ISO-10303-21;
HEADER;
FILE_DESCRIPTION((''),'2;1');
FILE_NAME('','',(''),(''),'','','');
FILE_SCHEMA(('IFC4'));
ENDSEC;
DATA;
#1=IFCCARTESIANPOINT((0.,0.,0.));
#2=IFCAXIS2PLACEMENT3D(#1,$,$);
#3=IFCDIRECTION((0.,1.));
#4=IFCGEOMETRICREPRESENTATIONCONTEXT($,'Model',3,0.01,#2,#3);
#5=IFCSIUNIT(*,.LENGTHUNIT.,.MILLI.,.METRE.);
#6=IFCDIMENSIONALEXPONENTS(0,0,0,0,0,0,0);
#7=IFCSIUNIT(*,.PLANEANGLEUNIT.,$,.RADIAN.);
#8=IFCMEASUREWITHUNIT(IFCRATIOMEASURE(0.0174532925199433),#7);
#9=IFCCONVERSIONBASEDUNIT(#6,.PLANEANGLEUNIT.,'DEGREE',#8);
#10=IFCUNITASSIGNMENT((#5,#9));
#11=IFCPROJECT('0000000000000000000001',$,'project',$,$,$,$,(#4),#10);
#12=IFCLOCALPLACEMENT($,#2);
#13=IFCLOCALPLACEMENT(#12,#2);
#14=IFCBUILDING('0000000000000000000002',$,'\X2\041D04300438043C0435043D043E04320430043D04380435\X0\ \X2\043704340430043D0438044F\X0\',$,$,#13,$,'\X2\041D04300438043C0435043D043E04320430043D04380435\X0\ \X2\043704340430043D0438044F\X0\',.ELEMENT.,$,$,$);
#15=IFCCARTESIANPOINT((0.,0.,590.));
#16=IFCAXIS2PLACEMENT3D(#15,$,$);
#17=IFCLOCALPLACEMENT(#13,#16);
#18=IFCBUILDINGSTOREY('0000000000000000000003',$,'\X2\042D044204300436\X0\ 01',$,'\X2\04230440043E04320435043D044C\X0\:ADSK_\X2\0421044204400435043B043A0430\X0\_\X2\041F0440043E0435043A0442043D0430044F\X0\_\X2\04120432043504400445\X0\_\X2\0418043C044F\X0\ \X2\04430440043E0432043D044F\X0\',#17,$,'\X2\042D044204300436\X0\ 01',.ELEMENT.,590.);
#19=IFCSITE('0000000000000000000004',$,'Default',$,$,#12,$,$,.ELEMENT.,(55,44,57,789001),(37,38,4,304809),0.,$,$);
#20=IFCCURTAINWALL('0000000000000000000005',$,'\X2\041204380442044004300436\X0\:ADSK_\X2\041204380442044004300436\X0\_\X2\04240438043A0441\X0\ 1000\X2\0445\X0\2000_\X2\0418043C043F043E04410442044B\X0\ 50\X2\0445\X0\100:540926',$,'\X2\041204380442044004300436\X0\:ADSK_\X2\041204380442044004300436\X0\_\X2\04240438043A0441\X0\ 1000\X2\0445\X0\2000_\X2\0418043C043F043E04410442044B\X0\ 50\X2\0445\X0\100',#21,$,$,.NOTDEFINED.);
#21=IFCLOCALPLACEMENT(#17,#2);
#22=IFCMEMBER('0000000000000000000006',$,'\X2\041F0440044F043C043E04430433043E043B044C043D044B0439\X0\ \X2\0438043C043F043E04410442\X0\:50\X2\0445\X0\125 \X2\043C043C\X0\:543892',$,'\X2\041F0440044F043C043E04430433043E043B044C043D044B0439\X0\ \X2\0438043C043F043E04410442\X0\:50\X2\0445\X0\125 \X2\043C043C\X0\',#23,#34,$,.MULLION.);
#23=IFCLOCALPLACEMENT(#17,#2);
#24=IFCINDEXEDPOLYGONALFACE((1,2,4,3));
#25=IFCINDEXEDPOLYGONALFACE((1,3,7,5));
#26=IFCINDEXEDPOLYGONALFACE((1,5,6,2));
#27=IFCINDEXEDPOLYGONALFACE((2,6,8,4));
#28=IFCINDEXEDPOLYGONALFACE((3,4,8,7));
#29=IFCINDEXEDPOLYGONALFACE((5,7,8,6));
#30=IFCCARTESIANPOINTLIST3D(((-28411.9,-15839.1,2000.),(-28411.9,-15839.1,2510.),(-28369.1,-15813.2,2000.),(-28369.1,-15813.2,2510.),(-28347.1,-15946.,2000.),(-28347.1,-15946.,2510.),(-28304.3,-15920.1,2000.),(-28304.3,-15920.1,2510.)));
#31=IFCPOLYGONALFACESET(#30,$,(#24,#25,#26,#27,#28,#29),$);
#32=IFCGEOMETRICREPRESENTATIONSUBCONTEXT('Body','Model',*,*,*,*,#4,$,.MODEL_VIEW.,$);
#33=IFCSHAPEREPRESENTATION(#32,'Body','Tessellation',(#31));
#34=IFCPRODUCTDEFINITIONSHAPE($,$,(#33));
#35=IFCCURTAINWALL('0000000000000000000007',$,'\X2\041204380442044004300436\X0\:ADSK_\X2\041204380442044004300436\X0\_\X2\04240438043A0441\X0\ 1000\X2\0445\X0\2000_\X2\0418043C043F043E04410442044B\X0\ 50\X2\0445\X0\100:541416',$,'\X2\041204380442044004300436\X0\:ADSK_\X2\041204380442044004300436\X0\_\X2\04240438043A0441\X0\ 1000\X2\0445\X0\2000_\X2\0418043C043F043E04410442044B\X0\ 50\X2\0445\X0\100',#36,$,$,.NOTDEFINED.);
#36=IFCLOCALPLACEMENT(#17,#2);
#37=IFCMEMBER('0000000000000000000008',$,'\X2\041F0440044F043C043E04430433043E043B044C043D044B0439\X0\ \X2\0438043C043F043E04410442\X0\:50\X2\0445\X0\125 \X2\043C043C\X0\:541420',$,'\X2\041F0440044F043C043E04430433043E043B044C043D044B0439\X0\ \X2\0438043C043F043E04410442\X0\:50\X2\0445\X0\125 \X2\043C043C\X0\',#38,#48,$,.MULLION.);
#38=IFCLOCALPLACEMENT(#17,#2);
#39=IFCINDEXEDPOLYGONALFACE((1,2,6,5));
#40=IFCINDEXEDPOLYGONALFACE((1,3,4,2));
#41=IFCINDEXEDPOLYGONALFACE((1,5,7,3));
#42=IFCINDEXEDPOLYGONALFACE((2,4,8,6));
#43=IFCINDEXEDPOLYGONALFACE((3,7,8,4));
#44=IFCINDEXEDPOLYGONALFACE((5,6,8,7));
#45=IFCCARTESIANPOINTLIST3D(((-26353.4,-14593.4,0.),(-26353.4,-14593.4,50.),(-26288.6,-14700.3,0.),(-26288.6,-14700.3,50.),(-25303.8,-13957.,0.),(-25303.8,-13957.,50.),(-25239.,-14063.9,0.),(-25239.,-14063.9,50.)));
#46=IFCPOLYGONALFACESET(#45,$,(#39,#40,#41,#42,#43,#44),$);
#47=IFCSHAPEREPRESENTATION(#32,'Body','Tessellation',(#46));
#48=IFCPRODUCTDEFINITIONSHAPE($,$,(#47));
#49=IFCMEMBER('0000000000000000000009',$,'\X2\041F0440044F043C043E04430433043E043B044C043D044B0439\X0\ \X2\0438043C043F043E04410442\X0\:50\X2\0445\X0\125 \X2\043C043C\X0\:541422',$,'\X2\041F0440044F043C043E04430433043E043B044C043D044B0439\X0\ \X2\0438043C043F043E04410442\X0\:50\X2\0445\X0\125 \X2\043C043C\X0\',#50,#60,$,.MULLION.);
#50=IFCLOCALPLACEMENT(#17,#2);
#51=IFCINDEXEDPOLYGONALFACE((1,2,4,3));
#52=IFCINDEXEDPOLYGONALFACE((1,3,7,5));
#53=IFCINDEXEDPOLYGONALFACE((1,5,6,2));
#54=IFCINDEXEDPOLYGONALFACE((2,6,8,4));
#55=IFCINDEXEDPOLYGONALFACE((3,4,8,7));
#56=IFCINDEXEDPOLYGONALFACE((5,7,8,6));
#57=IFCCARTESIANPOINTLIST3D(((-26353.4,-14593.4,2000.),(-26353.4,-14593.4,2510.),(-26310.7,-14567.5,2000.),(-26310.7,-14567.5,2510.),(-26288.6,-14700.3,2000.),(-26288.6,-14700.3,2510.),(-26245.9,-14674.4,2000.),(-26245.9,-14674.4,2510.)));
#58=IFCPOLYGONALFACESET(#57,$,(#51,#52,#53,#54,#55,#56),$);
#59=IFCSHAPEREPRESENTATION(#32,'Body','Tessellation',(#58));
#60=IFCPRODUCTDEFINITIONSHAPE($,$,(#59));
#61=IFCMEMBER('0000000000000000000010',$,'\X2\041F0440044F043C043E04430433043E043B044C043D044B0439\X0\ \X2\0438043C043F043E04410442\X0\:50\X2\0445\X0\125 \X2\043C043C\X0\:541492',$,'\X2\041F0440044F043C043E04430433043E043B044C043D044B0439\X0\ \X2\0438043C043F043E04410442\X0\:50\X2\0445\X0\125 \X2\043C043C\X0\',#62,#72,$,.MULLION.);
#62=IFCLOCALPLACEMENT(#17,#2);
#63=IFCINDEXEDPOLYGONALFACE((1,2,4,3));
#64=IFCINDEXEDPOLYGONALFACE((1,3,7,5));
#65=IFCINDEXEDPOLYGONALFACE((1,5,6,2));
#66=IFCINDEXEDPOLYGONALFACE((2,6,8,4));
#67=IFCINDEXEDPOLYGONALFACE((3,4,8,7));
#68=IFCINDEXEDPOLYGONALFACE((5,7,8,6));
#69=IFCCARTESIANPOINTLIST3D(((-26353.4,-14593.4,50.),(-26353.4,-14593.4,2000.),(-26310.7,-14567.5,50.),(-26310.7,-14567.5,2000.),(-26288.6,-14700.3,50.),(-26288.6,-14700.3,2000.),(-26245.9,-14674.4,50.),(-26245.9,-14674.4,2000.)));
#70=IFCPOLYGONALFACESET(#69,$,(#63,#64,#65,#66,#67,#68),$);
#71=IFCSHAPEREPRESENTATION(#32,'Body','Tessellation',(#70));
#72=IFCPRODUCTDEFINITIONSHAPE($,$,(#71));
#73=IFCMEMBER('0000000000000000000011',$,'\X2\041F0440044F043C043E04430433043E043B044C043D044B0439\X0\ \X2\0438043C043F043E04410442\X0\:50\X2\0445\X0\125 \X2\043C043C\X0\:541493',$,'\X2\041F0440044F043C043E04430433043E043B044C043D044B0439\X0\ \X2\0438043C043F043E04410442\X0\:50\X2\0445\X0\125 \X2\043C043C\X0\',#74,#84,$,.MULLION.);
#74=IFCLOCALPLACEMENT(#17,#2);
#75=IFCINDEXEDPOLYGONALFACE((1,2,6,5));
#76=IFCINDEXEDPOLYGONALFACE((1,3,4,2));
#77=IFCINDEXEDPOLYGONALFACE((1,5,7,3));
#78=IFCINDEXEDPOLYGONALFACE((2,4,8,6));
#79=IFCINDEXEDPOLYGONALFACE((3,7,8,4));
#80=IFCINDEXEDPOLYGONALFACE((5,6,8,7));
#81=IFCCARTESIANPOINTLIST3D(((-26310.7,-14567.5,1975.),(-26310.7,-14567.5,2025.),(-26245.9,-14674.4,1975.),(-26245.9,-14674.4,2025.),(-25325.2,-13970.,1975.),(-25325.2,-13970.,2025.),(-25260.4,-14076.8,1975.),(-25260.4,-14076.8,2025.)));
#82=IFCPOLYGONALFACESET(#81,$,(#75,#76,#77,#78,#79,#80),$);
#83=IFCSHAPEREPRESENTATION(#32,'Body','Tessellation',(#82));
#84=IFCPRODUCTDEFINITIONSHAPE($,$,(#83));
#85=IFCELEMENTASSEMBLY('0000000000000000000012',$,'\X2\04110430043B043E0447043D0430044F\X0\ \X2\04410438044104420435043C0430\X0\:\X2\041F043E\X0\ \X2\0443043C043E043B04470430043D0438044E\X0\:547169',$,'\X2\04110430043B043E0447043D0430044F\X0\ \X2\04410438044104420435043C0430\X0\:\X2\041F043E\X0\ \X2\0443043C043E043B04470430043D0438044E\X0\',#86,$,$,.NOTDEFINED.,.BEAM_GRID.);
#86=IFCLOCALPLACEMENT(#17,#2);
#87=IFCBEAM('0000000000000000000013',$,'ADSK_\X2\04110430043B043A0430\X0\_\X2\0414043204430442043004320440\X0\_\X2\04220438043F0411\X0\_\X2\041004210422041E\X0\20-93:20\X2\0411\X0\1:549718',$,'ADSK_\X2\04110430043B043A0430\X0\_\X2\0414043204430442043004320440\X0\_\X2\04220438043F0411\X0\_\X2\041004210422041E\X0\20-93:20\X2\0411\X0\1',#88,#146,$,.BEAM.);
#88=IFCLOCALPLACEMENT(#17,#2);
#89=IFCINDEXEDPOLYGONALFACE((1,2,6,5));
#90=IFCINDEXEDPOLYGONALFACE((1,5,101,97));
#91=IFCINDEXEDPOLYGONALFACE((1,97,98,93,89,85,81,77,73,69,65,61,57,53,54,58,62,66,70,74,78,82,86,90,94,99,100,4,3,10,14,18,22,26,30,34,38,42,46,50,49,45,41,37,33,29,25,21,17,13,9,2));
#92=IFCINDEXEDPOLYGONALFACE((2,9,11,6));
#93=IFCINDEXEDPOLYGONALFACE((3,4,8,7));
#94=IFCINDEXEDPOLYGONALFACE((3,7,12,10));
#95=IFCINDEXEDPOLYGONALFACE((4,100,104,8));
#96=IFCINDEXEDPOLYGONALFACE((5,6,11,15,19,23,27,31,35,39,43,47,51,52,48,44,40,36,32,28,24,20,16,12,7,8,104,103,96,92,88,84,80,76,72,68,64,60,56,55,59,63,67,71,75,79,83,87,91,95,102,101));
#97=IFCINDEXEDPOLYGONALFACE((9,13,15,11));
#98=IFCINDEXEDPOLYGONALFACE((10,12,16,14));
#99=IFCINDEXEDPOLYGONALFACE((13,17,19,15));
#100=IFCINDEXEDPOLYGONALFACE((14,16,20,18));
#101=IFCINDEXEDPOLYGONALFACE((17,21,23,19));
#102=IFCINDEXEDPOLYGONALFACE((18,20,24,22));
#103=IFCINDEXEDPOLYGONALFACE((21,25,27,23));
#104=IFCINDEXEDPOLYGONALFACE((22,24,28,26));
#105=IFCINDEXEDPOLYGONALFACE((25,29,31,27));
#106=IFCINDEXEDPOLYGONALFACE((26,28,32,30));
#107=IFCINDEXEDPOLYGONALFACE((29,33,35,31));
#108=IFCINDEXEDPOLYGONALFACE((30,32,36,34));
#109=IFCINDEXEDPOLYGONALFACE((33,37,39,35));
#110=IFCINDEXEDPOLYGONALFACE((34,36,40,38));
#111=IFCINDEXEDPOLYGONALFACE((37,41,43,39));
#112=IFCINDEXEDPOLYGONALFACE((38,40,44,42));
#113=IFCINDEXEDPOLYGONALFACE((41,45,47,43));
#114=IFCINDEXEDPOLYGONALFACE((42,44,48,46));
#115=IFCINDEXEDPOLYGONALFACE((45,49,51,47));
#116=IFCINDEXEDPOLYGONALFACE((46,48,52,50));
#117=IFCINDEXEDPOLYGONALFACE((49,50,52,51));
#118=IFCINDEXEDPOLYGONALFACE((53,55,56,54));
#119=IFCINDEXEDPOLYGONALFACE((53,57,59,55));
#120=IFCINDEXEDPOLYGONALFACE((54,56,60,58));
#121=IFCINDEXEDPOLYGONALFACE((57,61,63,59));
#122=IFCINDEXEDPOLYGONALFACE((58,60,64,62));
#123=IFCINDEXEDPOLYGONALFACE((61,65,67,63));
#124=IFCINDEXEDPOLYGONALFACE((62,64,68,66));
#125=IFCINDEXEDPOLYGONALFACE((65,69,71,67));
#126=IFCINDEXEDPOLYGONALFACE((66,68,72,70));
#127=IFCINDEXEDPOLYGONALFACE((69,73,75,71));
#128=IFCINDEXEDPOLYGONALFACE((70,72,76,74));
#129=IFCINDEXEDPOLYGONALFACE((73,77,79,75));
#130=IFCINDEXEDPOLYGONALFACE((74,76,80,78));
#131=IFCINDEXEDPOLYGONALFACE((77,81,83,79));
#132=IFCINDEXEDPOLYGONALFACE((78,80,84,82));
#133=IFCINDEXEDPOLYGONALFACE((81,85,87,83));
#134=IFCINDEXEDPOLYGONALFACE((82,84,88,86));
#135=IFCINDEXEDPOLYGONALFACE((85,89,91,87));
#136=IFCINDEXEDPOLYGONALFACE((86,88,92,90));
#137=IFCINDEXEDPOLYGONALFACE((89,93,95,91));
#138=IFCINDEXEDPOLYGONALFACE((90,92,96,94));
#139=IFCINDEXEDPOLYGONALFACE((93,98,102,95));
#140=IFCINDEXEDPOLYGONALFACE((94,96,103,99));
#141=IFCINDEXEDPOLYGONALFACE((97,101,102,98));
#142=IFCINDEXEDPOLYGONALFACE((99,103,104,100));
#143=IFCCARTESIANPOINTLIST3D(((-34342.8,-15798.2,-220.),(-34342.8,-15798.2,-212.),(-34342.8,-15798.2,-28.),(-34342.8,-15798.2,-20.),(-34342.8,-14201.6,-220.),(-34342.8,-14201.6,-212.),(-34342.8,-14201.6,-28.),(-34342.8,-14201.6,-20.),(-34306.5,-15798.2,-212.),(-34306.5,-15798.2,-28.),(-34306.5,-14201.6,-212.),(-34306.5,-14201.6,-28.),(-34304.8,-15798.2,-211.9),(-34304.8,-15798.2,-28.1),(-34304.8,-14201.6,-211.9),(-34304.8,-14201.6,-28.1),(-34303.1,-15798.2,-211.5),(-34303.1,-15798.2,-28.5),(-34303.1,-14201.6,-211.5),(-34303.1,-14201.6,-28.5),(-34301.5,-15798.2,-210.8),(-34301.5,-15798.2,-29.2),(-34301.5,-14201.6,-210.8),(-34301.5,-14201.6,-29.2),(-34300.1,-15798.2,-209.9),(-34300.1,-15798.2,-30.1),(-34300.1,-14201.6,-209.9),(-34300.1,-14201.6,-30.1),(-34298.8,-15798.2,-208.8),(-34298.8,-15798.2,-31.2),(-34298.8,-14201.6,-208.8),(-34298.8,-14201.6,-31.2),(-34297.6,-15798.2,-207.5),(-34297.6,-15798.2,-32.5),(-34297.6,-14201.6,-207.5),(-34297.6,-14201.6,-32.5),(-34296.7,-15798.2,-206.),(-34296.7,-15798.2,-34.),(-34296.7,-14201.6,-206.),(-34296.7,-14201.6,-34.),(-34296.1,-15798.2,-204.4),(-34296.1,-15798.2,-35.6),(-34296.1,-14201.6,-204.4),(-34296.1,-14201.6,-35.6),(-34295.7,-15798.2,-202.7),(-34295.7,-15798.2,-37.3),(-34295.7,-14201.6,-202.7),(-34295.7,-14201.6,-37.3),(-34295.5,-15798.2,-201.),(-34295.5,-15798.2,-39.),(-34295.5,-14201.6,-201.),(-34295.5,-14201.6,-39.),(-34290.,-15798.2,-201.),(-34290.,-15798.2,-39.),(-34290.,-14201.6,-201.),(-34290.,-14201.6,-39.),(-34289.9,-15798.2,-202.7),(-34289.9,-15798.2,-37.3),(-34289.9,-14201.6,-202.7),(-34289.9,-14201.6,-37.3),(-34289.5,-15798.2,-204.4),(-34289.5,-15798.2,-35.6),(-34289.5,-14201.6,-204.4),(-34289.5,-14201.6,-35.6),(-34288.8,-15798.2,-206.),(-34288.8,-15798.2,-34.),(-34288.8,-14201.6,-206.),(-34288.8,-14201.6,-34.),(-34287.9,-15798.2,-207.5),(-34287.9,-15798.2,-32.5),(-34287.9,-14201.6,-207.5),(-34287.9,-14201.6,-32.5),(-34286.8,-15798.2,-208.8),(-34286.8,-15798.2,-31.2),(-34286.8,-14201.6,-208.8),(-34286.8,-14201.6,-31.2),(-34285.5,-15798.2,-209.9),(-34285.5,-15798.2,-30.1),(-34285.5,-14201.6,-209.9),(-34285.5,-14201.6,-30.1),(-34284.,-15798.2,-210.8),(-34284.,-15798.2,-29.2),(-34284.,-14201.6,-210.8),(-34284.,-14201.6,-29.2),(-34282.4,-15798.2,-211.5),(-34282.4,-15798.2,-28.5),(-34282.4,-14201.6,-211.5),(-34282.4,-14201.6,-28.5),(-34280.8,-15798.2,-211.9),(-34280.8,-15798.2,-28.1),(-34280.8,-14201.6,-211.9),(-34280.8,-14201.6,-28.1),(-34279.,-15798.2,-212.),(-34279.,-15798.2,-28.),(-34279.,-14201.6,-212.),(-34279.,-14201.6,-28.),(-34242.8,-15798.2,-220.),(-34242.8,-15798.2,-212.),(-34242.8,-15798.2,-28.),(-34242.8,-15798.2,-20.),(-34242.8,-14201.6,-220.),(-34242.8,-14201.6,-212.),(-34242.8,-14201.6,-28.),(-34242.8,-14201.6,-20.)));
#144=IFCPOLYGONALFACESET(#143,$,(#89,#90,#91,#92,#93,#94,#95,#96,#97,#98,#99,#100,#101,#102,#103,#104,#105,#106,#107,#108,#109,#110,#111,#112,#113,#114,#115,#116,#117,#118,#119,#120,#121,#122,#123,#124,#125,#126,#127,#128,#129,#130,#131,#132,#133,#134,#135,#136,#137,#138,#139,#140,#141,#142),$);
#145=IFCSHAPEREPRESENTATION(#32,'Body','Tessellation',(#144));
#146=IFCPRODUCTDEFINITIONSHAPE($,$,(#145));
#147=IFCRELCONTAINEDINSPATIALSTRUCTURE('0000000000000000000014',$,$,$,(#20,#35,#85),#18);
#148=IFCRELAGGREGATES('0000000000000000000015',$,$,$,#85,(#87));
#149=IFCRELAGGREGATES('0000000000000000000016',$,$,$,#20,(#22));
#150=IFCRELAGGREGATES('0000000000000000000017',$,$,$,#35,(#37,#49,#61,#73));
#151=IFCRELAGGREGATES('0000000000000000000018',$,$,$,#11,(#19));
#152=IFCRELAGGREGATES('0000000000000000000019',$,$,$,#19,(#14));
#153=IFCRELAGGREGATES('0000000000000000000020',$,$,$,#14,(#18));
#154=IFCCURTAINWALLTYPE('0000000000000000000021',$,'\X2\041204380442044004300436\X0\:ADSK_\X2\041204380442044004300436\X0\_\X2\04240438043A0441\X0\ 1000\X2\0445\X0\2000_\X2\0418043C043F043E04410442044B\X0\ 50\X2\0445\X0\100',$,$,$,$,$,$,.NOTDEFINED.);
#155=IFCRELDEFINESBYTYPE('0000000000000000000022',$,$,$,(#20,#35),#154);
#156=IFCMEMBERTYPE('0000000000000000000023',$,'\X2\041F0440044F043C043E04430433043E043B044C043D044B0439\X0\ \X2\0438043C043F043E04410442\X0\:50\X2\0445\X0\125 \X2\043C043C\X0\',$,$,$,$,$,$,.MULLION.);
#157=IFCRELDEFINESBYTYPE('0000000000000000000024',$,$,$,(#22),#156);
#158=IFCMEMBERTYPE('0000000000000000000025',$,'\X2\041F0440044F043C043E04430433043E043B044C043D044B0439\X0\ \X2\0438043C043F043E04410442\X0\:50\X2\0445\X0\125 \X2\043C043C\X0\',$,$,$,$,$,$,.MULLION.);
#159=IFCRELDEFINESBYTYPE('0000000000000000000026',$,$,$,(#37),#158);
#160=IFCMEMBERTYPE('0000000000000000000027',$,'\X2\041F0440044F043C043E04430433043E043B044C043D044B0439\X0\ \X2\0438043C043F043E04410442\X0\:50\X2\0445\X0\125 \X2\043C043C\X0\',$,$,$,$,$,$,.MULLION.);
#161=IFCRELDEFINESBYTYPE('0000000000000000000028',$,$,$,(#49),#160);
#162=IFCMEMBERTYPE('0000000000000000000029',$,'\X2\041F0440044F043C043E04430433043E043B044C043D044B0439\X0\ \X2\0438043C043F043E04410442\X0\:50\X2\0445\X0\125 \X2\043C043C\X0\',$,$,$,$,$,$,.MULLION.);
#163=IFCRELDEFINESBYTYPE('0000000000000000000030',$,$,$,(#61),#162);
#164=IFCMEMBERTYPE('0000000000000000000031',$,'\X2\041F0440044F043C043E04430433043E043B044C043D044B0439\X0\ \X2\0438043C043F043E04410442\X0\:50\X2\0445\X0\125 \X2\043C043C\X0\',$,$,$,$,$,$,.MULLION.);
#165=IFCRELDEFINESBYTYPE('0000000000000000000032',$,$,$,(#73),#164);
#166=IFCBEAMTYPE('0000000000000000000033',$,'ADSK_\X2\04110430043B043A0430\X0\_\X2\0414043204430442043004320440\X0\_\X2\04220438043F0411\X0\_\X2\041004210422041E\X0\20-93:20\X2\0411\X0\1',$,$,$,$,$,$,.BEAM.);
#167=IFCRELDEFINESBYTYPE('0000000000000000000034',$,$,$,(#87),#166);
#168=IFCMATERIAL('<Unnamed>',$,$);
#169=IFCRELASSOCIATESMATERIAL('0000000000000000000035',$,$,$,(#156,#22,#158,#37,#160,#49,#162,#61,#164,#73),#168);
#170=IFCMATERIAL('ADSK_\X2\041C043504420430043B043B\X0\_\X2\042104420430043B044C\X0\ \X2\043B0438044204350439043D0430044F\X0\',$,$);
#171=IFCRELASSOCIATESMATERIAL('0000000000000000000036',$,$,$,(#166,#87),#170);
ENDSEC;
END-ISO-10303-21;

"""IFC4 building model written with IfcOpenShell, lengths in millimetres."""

from ifc_helpers import new_model, entity, si_unit, converted_unit, direction, frame, origin, place, context, subcontext, project, spatial, indexed_curve, outline, extrude, source, transform, mapped, material, type_object, type_shapes, element, aggregate, save


model = new_model("IFC4")

# Units and contexts
model_context = context("Model", 3, precision=0.01, world=origin(), true_north=direction((0.0, 1.0)))
body_context = subcontext(model_context, "Body", "Model", "MODEL_VIEW")
ifc_project = project(units=[si_unit("LENGTHUNIT", "METRE", prefix="MILLI"), converted_unit("PLANEANGLEUNIT", "DEGREE", entity("IfcRatioMeasure", 0.0174532925199433), si_unit("PLANEANGLEUNIT", "RADIAN"), dimensions=[0, 0, 0, 0, 0, 0, 0])], contexts=[model_context])

# Site, building, storey
site_placement = place(None, origin())
site = spatial("IfcSite", under=ifc_project, at=site_placement, Name="Default", CompositionType="ELEMENT", RefLatitude=(55, 44, 57, 789001), RefLongitude=(37, 38, 4, 304809), RefElevation=0.0)
building_placement = place(site_placement, origin())
building = spatial("IfcBuilding", under=site, at=building_placement, Name="Наименование здания", LongName="Наименование здания", CompositionType="ELEMENT")
storey_placement = place(building_placement, frame((0.0, 0.0, 590.0)))
storey = spatial("IfcBuildingStorey", under=building, at=storey_placement, Name="Этаж 01", ObjectType="Уровень:ADSK_Стрелка_Проектная_Вверх_Имя уровня", LongName="Этаж 01", CompositionType="ELEMENT", Elevation=590.0)

# Curtain walls, members
curtain_wall_type = type_object("IfcCurtainWallType", Name="Витраж:ADSK_Витраж_Фикс 1000х2000_Импосты 50х100", PredefinedType="NOTDEFINED")
curtain_wall_1_placement = place(storey_placement, frame((0.0, 0.0, -590.0)))
curtain_wall_1 = element("IfcCurtainWall", 1, at=curtain_wall_1_placement, inside=storey, type_object=curtain_wall_type, Name="Витраж:ADSK_Витраж_Фикс 1000х2000_Импосты 50х100:540926", ObjectType="Витраж:ADSK_Витраж_Фикс 1000х2000_Импосты 50х100", PredefinedType="NOTDEFINED")
ifc_material_1 = material(Name="<Unnamed>")
member_type_1 = type_object("IfcMemberType", Name="Прямоугольный импост:50х125 мм", PredefinedType="MULLION", material=ifc_material_1)
shared_shape_1 = source(origin(), body_context, "Body", "SweptSolid", [
    extrude(outline(indexed_curve([(-62.5, -25.0), (62.5, -25.0), (62.5, 25.0), (-62.5, 25.0), (-62.5, -25.0)], self_intersect=False)), frame((0.0, 0.0, -510.0), z_axis=(0.0, 0.0, 1.0), x_axis=(0.0, -1.0, 0.0)), (0.0, 0.0, 1.0), 510.0),
])
type_shapes(member_type_1, [shared_shape_1])
member_1_placement = place(storey_placement, frame((-28358.1, -15879.6, 2000.0), z_axis=(0.0, 0.0, -1.0), x_axis=(0.855267, 0.518188, 0.0)))
member_1 = element("IfcMember", 2, at=member_1_placement, type_object=member_type_1, material=ifc_material_1, Name="Прямоугольный импост:50х125 мм:543892", ObjectType="Прямоугольный импост:50х125 мм", PredefinedType="MULLION", context=body_context, shape_type="MappedRepresentation", body=[
    mapped(shared_shape_1, transform((0.0, 0.0, 0.0), scale=1.0)),
])
curtain_wall_2_placement = place(storey_placement, frame((0.0, 0.0, -590.0)))
curtain_wall_2 = element("IfcCurtainWall", 3, at=curtain_wall_2_placement, inside=storey, type_object=curtain_wall_type, Name="Витраж:ADSK_Витраж_Фикс 1000х2000_Импосты 50х100:541416", ObjectType="Витраж:ADSK_Витраж_Фикс 1000х2000_Импосты 50х100", PredefinedType="NOTDEFINED")
member_type_2 = type_object("IfcMemberType", Name="Прямоугольный импост:50х125 мм", PredefinedType="MULLION", material=ifc_material_1)
shared_shape_2 = source(origin(), body_context, "Body", "SweptSolid", [
    extrude(outline(indexed_curve([(-62.5, -25.0), (62.5, -25.0), (62.5, 25.0), (-62.5, 25.0), (-62.5, -25.0)], self_intersect=False)), frame((-25.0, 0.0, -1227.5), z_axis=(0.0, 0.0, 1.0), x_axis=(0.0, -1.0, 0.0)), (0.0, 0.0, 1.0), 1227.5),
])
type_shapes(member_type_2, [shared_shape_2])
member_2_placement = place(storey_placement, frame((-26321.0, -14646.8, 0.0), z_axis=(-0.855102, -0.51846, 0.0), x_axis=(0.0, 0.0, -1.0)))
member_2 = element("IfcMember", 4, at=member_2_placement, type_object=member_type_2, material=ifc_material_1, Name="Прямоугольный импост:50х125 мм:541420", ObjectType="Прямоугольный импост:50х125 мм", PredefinedType="MULLION", context=body_context, shape_type="MappedRepresentation", body=[
    mapped(shared_shape_2, transform((0.0, 0.0, 0.0), scale=1.0)),
])
member_type_3 = type_object("IfcMemberType", Name="Прямоугольный импост:50х125 мм", PredefinedType="MULLION", material=ifc_material_1)
shared_shape_3 = source(origin(), body_context, "Body", "SweptSolid", [
    extrude(outline(indexed_curve([(-62.5, -25.0), (62.5, -25.0), (62.5, 25.0), (-62.5, 25.0), (-62.5, -25.0)], self_intersect=False)), frame((-25.0, 0.0, -510.0), z_axis=(0.0, 0.0, 1.0), x_axis=(0.0, -1.0, 0.0)), (0.0, 0.0, 1.0), 510.0),
])
type_shapes(member_type_3, [shared_shape_3])
member_3_placement = place(storey_placement, frame((-26321.0, -14646.8, 2510.0), z_axis=(0.0, 0.0, 1.0), x_axis=(-0.855102, -0.51846, 0.0)))
member_3 = element("IfcMember", 5, at=member_3_placement, type_object=member_type_3, material=ifc_material_1, Name="Прямоугольный импост:50х125 мм:541422", ObjectType="Прямоугольный импост:50х125 мм", PredefinedType="MULLION", context=body_context, shape_type="MappedRepresentation", body=[
    mapped(shared_shape_3, transform((0.0, 0.0, 0.0), scale=1.0)),
])
member_type_4 = type_object("IfcMemberType", Name="Прямоугольный импост:50х125 мм", PredefinedType="MULLION", material=ifc_material_1)
shared_shape_4 = source(origin(), body_context, "Body", "SweptSolid", [
    extrude(outline(indexed_curve([(-62.5, -25.0), (62.5, -25.0), (62.5, 25.0), (-62.5, 25.0), (-62.5, -25.0)], self_intersect=False)), frame((-25.0, 0.0, -1950.0), z_axis=(0.0, 0.0, 1.0), x_axis=(0.0, -1.0, 0.0)), (0.0, 0.0, 1.0), 1950.0),
])
type_shapes(member_type_4, [shared_shape_4])
member_4_placement = place(storey_placement, frame((-26321.0, -14646.8, 2000.0), z_axis=(0.0, 0.0, 1.0), x_axis=(-0.855102, -0.51846, 0.0)))
member_4 = element("IfcMember", 6, at=member_4_placement, type_object=member_type_4, material=ifc_material_1, Name="Прямоугольный импост:50х125 мм:541492", ObjectType="Прямоугольный импост:50х125 мм", PredefinedType="MULLION", context=body_context, shape_type="MappedRepresentation", body=[
    mapped(shared_shape_4, transform((0.0, 0.0, 0.0), scale=1.0)),
])
member_type_5 = type_object("IfcMemberType", Name="Прямоугольный импост:50х125 мм", PredefinedType="MULLION", material=ifc_material_1)
shared_shape_5 = source(origin(), body_context, "Body", "SweptSolid", [
    extrude(outline(indexed_curve([(-62.5, -25.0), (62.5, -25.0), (62.5, 25.0), (-62.5, 25.0), (-62.5, -25.0)], self_intersect=False)), frame((0.0, 0.0, -1152.5), z_axis=(0.0, 0.0, 1.0), x_axis=(0.0, -1.0, 0.0)), (0.0, 0.0, 1.0), 1152.5),
])
type_shapes(member_type_5, [shared_shape_5])
member_5_placement = place(storey_placement, frame((-25292.8, -14023.4, 2000.0), z_axis=(0.855102, 0.51846, 0.0), x_axis=(0.0, 0.0, 1.0)))
member_5 = element("IfcMember", 7, at=member_5_placement, type_object=member_type_5, material=ifc_material_1, Name="Прямоугольный импост:50х125 мм:541493", ObjectType="Прямоугольный импост:50х125 мм", PredefinedType="MULLION", context=body_context, shape_type="MappedRepresentation", body=[
    mapped(shared_shape_5, transform((0.0, 0.0, 0.0), scale=1.0)),
])

# Element assembly, beam
assembly_placement = place(storey_placement, origin())
assembly = element("IfcElementAssembly", 8, at=assembly_placement, inside=storey, Name="Балочная система:По умолчанию:547169", ObjectType="Балочная система:По умолчанию", AssemblyPlace="NOTDEFINED", PredefinedType="BEAM_GRID")
ifc_material_2 = material(Name="ADSK_Металл_Сталь литейная")
beam_type_1 = type_object("IfcBeamType", Name="ADSK_Балка_Двутавр_ТипБ_АСТО20-93:20Б1", PredefinedType="BEAM", material=ifc_material_2)
shared_shape_6 = source(origin(), body_context, "Body", "SweptSolid", [
    extrude(outline(indexed_curve([(-100.0, -50.0), (-92.0, -50.0), (-92.0, -13.8), (-91.9, -12.0), (-91.5, -10.4), (-90.8, -8.8), (-89.9, -7.3), (-88.8, -6.0), (-87.5, -4.9), (-86.0, -3.9), (-84.4, -3.3), (-82.7, -2.9), (-81.0, -2.8), (81.0, -2.8), (82.7, -2.9), (84.4, -3.3), (86.0, -3.9), (87.5, -4.9), (88.8, -6.0), (89.9, -7.3), (90.8, -8.8), (91.5, -10.4), (91.9, -12.0), (92.0, -13.7), (92.0, -50.0), (100.0, -50.0), (100.0, 50.0), (92.0, 50.0), (92.0, 13.8), (91.9, 12.0), (91.5, 10.4), (90.8, 8.8), (89.9, 7.3), (88.8, 6.0), (87.5, 4.9), (86.0, 3.9), (84.4, 3.3), (82.7, 2.9), (81.0, 2.8), (-81.0, 2.8), (-82.7, 2.9), (-84.4, 3.3), (-86.0, 3.9), (-87.5, 4.9), (-88.8, 6.0), (-89.9, 7.3), (-90.8, 8.8), (-91.5, 10.4), (-91.9, 12.0), (-92.0, 13.8), (-92.0, 50.0), (-100.0, 50.0), (-100.0, -50.0)], self_intersect=False)), frame((-798.3, 0.0, -100.0), z_axis=(1.0, 0.0, 0.0), x_axis=(0.0, 0.0, -1.0)), (0.0, 0.0, 1.0), 1596.5),
])
type_shapes(beam_type_1, [shared_shape_6])
beam_1_placement = place(assembly_placement, frame((-34292.8, -14999.9, -20.0), z_axis=(0.0, 0.0, 1.0), x_axis=(0.0, 1.0, 0.0)))
beam_1 = element("IfcBeam", 9, at=beam_1_placement, type_object=beam_type_1, material=ifc_material_2, Name="ADSK_Балка_Двутавр_ТипБ_АСТО20-93:20Б1:549718", ObjectType="ADSK_Балка_Двутавр_ТипБ_АСТО20-93:20Б1", PredefinedType="BEAM", context=body_context, shape_type="MappedRepresentation", body=[
    mapped(shared_shape_6, transform((0.0, 0.0, 0.0), scale=1.0)),
])
aggregate(assembly, [beam_1])

aggregate(curtain_wall_1, [member_1])
aggregate(curtain_wall_2, [member_2, member_3, member_4, member_5])

save(model, "model.ifc")
